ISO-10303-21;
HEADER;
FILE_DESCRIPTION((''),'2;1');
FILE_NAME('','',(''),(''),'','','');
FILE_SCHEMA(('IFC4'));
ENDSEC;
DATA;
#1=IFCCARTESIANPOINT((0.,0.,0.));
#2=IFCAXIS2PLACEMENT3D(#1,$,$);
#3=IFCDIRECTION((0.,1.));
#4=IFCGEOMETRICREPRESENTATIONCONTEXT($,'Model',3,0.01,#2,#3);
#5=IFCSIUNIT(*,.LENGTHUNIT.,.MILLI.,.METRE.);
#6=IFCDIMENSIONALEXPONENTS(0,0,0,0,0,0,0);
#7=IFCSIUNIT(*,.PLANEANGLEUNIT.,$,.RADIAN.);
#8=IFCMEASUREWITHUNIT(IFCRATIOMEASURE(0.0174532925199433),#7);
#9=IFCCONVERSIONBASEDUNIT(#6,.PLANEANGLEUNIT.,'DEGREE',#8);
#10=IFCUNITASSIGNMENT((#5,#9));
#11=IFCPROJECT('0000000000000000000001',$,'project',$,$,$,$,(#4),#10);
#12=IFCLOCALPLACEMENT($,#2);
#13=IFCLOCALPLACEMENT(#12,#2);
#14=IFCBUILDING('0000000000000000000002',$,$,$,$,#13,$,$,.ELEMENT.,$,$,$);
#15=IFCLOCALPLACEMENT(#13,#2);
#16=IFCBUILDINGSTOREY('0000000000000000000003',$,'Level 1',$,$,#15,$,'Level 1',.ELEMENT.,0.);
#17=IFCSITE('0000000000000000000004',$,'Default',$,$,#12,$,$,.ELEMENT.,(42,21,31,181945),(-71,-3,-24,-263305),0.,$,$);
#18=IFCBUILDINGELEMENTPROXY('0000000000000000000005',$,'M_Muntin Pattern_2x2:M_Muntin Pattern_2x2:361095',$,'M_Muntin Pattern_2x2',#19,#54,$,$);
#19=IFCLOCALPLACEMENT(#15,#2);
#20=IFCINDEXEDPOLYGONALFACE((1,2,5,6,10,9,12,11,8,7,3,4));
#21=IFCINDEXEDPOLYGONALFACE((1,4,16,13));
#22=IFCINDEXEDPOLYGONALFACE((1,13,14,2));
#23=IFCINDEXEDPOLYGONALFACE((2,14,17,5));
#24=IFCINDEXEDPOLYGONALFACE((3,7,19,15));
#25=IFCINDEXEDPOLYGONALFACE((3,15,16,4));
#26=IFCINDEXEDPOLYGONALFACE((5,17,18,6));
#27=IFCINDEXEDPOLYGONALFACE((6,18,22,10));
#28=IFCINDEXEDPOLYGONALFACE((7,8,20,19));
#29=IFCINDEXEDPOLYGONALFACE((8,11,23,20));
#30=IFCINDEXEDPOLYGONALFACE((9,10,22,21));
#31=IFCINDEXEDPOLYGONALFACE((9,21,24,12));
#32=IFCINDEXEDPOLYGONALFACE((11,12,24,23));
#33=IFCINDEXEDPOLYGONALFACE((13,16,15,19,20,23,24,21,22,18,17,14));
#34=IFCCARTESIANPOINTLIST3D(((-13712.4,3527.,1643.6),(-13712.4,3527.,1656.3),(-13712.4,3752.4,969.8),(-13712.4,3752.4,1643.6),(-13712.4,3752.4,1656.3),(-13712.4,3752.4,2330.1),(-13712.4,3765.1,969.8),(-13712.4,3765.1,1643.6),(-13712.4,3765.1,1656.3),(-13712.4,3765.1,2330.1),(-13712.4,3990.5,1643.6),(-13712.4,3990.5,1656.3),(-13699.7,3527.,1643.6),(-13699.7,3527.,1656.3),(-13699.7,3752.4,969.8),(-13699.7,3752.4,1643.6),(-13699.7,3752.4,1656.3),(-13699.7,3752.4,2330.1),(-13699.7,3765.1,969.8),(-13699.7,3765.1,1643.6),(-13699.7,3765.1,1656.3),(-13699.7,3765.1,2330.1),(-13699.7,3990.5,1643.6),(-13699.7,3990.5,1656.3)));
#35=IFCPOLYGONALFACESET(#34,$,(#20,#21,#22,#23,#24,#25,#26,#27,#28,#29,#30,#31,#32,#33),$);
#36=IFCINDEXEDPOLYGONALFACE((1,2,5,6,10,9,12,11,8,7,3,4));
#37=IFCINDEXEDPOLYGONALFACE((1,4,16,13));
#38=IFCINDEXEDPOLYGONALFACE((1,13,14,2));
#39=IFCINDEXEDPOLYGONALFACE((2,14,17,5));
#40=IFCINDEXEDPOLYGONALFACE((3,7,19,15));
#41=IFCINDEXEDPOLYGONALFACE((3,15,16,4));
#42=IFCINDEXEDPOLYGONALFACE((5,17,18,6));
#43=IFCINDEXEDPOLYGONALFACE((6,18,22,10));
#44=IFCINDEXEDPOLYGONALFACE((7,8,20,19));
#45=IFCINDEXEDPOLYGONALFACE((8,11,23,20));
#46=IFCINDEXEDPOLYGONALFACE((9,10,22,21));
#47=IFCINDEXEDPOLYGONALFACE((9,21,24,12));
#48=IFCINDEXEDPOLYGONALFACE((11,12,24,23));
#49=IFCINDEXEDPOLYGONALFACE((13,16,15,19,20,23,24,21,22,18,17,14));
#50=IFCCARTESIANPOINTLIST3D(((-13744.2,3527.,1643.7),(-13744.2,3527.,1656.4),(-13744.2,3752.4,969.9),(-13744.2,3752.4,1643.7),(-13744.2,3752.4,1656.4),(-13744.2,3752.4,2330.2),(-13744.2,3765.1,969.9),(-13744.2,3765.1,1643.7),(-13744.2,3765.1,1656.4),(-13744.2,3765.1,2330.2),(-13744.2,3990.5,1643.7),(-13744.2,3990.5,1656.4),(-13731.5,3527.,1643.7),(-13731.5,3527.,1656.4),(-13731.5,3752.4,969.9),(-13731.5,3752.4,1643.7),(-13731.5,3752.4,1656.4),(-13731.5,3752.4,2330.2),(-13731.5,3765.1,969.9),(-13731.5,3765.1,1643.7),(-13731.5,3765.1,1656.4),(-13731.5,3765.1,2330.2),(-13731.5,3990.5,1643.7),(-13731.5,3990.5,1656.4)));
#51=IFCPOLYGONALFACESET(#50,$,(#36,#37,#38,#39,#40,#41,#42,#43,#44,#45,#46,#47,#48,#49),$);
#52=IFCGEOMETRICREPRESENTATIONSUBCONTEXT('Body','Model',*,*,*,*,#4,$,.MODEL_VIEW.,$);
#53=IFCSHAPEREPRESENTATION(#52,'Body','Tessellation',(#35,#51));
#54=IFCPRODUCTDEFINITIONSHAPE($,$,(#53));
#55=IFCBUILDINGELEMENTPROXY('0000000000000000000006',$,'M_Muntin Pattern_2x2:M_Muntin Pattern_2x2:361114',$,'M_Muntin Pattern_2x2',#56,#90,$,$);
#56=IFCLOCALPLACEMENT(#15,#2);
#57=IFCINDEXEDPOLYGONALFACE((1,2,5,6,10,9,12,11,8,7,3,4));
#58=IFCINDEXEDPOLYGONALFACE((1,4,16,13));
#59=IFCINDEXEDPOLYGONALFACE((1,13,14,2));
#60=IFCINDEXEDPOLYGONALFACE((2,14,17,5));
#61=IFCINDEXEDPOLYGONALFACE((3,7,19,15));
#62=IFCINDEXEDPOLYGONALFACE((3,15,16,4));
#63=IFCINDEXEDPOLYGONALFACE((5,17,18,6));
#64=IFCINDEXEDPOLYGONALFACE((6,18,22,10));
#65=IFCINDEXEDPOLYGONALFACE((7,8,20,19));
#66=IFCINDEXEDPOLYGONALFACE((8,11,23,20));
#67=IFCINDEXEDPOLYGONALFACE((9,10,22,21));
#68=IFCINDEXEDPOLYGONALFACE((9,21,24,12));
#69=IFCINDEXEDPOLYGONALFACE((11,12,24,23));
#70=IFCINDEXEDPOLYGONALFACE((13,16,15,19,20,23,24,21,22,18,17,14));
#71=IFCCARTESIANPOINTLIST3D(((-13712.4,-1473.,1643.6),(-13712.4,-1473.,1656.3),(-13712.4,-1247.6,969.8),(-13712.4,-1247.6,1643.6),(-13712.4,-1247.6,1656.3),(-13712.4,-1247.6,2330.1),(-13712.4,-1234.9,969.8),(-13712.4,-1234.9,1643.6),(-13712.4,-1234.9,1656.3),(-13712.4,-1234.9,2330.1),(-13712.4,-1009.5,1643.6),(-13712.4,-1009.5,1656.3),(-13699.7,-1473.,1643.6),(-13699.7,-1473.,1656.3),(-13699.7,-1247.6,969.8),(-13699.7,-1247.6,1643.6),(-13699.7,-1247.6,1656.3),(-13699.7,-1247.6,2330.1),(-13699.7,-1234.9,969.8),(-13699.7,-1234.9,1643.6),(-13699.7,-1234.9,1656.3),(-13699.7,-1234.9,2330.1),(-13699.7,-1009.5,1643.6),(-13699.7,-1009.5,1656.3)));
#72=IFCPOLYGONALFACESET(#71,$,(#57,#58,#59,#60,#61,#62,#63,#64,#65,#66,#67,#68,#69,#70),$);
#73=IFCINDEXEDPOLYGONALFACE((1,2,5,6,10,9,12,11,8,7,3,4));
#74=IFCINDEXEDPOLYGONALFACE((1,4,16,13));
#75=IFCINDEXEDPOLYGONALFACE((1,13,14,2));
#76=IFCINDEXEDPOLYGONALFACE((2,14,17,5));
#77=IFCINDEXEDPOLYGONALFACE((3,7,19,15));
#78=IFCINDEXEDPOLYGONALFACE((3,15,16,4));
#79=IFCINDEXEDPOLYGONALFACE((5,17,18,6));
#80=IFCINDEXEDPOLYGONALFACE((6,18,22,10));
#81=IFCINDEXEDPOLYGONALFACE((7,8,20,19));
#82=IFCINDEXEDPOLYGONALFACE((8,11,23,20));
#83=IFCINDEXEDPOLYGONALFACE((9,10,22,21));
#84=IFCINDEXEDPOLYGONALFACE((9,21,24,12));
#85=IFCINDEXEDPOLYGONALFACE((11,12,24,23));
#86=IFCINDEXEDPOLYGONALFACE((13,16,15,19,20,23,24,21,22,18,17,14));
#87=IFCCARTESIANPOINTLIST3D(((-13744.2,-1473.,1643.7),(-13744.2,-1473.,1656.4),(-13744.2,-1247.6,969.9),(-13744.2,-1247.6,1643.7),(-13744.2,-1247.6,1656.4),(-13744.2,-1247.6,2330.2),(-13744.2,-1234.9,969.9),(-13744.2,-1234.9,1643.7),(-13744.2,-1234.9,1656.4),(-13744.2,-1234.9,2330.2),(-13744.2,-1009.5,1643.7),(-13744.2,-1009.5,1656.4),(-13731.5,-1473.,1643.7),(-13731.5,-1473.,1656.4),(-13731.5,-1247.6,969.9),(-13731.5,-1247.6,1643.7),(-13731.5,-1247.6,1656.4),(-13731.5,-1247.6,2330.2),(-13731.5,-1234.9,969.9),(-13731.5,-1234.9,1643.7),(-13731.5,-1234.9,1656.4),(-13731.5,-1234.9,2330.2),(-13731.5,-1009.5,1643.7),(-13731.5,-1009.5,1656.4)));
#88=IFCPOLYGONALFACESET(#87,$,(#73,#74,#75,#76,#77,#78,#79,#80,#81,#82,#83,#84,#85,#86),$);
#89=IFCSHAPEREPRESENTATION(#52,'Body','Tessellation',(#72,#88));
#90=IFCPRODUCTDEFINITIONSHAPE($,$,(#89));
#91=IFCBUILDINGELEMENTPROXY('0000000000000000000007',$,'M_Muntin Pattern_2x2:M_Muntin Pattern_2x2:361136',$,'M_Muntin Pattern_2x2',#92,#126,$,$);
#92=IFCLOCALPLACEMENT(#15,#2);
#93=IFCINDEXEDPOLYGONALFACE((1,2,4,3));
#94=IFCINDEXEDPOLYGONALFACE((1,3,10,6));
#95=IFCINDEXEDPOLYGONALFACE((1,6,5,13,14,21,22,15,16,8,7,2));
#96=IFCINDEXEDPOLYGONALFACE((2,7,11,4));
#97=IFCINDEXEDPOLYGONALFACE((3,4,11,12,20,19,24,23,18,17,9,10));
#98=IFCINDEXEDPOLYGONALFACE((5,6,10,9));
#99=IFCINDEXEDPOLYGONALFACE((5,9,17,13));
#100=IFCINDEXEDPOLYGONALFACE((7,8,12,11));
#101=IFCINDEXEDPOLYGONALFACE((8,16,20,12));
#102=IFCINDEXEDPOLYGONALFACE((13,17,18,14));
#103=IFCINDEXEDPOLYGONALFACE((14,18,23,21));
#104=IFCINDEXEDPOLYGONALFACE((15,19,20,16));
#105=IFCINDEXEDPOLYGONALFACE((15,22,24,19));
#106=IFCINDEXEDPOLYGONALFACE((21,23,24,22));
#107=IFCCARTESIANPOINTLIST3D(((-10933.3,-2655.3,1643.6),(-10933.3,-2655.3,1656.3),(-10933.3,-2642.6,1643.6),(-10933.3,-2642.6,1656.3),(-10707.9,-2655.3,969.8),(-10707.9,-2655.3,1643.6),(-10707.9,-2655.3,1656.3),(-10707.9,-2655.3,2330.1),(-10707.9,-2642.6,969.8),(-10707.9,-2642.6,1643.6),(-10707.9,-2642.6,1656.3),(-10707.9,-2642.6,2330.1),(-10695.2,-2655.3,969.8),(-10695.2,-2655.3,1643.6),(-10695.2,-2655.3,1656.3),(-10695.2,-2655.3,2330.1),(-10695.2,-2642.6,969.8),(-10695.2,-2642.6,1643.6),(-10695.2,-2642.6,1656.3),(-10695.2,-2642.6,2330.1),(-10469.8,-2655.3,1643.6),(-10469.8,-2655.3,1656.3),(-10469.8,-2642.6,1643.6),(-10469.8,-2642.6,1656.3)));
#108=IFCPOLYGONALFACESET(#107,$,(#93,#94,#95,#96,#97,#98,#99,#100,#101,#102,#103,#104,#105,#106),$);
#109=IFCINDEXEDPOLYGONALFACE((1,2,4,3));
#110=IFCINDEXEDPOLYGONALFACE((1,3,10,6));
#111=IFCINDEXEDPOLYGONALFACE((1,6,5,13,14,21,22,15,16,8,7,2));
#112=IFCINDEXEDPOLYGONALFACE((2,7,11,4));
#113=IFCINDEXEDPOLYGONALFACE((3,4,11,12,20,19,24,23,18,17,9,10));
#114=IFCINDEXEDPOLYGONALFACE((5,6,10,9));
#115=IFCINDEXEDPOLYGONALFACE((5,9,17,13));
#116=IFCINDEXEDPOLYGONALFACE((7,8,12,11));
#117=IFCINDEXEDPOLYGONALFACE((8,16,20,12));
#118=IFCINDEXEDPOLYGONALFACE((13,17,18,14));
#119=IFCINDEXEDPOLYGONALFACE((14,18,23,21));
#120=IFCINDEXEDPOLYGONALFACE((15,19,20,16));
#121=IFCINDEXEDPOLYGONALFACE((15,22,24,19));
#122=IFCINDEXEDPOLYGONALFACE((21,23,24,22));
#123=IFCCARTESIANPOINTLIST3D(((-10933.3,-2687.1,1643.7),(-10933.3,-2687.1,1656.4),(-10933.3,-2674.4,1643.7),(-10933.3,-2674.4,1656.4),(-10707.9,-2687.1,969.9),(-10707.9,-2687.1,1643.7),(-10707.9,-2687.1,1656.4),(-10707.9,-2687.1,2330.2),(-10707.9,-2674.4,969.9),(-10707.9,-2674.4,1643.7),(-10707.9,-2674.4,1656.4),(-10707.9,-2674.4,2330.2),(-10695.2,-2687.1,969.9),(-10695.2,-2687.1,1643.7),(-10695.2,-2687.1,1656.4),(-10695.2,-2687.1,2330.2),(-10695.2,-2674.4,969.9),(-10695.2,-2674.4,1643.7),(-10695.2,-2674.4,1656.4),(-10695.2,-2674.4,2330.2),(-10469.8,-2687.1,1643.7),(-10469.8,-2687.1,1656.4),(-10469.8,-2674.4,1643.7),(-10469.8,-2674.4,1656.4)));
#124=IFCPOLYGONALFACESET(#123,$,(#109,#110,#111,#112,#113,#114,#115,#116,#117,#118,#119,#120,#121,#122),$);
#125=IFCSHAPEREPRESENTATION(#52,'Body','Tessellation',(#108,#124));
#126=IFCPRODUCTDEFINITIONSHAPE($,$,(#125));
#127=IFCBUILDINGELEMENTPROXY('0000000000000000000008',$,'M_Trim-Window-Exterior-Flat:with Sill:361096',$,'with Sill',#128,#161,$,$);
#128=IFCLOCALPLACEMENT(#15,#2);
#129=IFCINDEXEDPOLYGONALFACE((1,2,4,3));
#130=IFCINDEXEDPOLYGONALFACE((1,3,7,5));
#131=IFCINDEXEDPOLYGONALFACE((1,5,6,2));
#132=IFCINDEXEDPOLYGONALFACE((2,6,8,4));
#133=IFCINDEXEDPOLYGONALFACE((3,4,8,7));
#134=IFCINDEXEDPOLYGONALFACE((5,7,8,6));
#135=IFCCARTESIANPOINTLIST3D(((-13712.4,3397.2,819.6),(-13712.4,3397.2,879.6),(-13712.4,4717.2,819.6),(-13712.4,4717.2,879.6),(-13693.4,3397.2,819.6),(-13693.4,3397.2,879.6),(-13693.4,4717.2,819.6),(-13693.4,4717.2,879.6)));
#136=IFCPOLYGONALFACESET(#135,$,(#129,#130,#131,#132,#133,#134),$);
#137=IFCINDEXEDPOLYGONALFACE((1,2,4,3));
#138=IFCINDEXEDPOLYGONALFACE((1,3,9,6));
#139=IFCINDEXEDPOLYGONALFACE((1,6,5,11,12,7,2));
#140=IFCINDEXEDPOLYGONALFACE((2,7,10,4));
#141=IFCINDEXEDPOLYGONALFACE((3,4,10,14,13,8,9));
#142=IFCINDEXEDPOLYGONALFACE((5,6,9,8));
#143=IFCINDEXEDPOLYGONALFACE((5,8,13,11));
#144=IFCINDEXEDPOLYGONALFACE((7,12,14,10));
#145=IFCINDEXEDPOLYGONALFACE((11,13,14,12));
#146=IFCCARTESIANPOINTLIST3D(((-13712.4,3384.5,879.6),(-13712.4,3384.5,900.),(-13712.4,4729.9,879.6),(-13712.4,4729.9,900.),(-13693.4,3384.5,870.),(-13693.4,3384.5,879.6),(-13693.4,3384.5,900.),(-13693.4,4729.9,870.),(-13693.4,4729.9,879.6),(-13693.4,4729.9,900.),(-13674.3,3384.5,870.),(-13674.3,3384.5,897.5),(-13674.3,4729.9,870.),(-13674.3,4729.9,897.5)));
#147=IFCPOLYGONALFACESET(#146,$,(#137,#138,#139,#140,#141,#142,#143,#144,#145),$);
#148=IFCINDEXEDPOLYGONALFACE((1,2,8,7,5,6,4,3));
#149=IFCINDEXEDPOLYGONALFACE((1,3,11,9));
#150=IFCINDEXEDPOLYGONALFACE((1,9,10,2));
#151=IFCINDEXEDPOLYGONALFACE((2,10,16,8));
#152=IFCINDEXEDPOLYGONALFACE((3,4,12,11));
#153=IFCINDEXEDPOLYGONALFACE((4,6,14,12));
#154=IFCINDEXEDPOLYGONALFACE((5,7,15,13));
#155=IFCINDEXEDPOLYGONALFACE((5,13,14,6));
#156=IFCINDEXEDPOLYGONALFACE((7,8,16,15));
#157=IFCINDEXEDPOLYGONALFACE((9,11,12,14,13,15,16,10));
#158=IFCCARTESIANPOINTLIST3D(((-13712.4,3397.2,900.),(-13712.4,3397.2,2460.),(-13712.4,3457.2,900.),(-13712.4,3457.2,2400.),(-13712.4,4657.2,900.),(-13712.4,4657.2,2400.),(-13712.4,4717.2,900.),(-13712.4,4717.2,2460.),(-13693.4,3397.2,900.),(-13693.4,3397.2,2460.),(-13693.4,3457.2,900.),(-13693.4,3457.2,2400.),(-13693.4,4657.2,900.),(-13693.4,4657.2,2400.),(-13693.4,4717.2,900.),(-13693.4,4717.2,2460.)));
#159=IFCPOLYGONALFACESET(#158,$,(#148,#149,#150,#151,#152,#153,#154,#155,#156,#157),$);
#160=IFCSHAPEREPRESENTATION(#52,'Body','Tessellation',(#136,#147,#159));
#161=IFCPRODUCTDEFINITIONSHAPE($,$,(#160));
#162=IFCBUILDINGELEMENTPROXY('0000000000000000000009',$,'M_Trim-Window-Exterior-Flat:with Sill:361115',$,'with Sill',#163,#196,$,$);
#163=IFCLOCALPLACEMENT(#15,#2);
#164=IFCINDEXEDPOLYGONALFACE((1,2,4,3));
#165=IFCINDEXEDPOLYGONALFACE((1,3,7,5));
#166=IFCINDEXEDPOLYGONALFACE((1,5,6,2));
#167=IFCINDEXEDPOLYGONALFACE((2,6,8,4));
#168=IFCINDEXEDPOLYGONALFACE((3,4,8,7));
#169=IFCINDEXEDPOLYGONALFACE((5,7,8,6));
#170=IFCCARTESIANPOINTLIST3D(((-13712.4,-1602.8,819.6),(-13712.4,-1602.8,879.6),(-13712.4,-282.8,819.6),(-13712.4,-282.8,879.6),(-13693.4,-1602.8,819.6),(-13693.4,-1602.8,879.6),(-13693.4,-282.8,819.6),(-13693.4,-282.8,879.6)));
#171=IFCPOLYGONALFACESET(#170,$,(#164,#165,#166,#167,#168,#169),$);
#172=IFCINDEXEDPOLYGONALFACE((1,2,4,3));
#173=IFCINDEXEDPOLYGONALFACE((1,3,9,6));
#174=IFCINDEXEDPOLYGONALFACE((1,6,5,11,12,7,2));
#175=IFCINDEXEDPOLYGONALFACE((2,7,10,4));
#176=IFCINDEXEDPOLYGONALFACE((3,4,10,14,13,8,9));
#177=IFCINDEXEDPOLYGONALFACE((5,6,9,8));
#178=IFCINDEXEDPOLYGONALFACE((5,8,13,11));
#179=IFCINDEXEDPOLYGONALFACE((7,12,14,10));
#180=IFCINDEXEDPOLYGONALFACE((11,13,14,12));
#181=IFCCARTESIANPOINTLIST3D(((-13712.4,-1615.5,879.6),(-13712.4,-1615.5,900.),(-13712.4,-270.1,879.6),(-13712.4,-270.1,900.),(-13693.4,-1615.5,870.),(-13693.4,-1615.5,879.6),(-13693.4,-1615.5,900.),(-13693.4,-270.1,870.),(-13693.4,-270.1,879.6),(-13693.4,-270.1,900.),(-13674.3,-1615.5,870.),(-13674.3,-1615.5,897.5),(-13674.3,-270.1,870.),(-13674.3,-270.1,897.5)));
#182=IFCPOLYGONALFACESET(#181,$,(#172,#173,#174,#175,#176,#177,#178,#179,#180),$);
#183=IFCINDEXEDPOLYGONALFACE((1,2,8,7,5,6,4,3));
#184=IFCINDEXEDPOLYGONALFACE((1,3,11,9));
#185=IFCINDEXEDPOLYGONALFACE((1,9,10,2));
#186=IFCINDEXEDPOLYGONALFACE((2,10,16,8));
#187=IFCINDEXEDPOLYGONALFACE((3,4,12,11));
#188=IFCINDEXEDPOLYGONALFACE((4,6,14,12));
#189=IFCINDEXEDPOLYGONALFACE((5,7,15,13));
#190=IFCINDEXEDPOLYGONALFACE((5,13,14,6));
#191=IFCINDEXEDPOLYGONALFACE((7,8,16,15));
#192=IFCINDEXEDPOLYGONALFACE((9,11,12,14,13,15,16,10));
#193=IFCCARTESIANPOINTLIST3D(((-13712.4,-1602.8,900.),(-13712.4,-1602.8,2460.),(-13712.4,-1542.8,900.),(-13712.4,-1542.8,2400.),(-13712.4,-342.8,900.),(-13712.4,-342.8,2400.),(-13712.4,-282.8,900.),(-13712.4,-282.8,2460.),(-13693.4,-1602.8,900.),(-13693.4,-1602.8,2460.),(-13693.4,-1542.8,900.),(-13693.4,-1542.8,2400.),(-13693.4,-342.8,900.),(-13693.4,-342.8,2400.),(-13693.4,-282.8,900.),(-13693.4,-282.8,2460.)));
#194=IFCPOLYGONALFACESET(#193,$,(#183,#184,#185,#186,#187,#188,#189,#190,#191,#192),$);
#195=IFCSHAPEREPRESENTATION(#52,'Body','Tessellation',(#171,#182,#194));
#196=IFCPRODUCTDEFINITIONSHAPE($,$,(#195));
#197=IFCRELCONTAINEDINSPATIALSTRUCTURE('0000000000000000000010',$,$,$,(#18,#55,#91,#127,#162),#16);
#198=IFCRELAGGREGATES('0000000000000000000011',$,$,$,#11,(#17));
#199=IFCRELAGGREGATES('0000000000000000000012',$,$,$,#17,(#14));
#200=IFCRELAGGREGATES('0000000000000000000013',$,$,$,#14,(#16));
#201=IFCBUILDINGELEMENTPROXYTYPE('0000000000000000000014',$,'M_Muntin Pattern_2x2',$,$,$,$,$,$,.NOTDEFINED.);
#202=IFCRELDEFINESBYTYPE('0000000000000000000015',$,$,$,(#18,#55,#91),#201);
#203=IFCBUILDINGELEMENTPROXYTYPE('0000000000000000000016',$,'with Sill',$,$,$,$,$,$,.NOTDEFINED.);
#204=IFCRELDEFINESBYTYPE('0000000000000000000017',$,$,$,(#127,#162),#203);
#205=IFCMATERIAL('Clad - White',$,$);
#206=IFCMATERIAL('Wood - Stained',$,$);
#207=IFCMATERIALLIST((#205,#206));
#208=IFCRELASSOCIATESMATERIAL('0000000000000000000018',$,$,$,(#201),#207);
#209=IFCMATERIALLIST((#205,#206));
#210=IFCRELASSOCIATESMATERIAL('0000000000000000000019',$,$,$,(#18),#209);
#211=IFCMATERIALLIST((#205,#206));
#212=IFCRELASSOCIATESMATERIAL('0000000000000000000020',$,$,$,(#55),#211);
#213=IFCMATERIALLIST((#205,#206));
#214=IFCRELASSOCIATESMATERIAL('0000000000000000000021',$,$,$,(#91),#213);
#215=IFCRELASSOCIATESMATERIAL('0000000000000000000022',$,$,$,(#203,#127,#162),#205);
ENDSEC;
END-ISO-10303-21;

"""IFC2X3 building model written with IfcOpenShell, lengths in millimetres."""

from ifc_helpers import new_model, entity, si_unit, converted_unit, direction, frame, frame_2d, origin, place, context, subcontext, project, spatial, polyline, rectangle, outline, extrude, source, transform, mapped, material, material_list, type_object, type_shapes, element, save


model = new_model("IFC2X3")

# Units and contexts
model_context = context("Model", 3, precision=0.01, world=origin(), true_north=direction((0.0, 1.0)))
body_context = subcontext(model_context, "Body", "Model", "MODEL_VIEW")
ifc_project = project(units=[si_unit("LENGTHUNIT", "METRE", prefix="MILLI"), converted_unit("PLANEANGLEUNIT", "DEGREE", entity("IfcRatioMeasure", 0.0174532925199433), si_unit("PLANEANGLEUNIT", "RADIAN"), dimensions=[0, 0, 0, 0, 0, 0, 0])], contexts=[model_context])

# Site, building, storey
site_placement = place(None, origin())
site = spatial("IfcSite", under=ifc_project, at=site_placement, Name="Default", CompositionType="ELEMENT", RefLatitude=(42, 21, 31, 181945), RefLongitude=(-71, -3, -24, -263305), RefElevation=0.0)
building_placement = place(site_placement, origin())
building = spatial("IfcBuilding", under=site, at=building_placement, CompositionType="ELEMENT")
storey_placement = place(building_placement, origin())
storey = spatial("IfcBuildingStorey", under=building, at=storey_placement, Name="Level 1", LongName="Level 1", CompositionType="ELEMENT", Elevation=0.0)

# Building element proxies
ifc_material_1 = material(Name="Clad - White")
ifc_material_2 = material(Name="Wood - Stained")
ifc_material_list_1 = material_list([ifc_material_1, ifc_material_2])
ifc_material_list_2 = material_list([ifc_material_1, ifc_material_2])
building_element_proxy_type_1 = type_object("IfcBuildingElementProxyType", Name="M_Muntin Pattern_2x2", PredefinedType="NOTDEFINED", material=ifc_material_list_2)
shared_shape_1 = source(origin(), body_context, "Body", "SweptSolid", [
    extrude(outline(polyline([(6.4, -6.4), (680.1, -6.4), (680.1, 6.3), (6.4, 6.3), (6.4, 231.7), (-6.3, 231.7), (-6.3, 6.3), (-680.2, 6.3), (-680.2, -6.4), (-6.3, -6.4), (-6.3, -231.7), (6.4, -231.7), (6.4, -6.4)])), frame((0.0, -22.2, 680.1), z_axis=(0.0, 1.0, 0.0), x_axis=(0.0, 0.0, 1.0)), (0.0, 0.0, 1.0), 12.7),
    extrude(outline(polyline([(6.4, -6.4), (680.1, -6.4), (680.1, 6.3), (6.4, 6.3), (6.4, 231.7), (-6.3, 231.7), (-6.3, 6.3), (-680.2, 6.3), (-680.2, -6.4), (-6.3, -6.4), (-6.3, -231.7), (6.4, -231.7), (6.4, -6.4)])), frame((0.0, 9.5, 680.2), z_axis=(0.0, 1.0, 0.0), x_axis=(0.0, 0.0, 1.0)), (0.0, 0.0, 1.0), 12.7),
])
type_shapes(building_element_proxy_type_1, [shared_shape_1])
proxy_1_placement = place(storey_placement, frame((-13722.0, 3758.7, 969.9), z_axis=(0.0, 0.0, 1.0), x_axis=(0.0, 1.0, 0.0)))
element("IfcBuildingElementProxy", 1, at=proxy_1_placement, inside=storey, type_object=building_element_proxy_type_1, material=ifc_material_list_1, Name="M_Muntin Pattern_2x2:M_Muntin Pattern_2x2:361095", ObjectType="M_Muntin Pattern_2x2", context=body_context, shape_type="MappedRepresentation", body=[
    mapped(shared_shape_1, transform((0.0, 0.0, 0.0), scale=1.0)),
])
ifc_material_list_3 = material_list([ifc_material_1, ifc_material_2])
proxy_2_placement = place(storey_placement, frame((-13722.0, -1241.3, 969.9), z_axis=(0.0, 0.0, 1.0), x_axis=(0.0, 1.0, 0.0)))
element("IfcBuildingElementProxy", 2, at=proxy_2_placement, inside=storey, type_object=building_element_proxy_type_1, material=ifc_material_list_3, Name="M_Muntin Pattern_2x2:M_Muntin Pattern_2x2:361114", ObjectType="M_Muntin Pattern_2x2", context=body_context, shape_type="MappedRepresentation", body=[
    mapped(shared_shape_1, transform((0.0, 0.0, 0.0), scale=1.0)),
])
ifc_material_list_4 = material_list([ifc_material_1, ifc_material_2])
proxy_3_placement = place(storey_placement, frame((-10701.5, -2664.9, 969.9), z_axis=(0.0, 0.0, 1.0), x_axis=(-1.0, 0.0, 0.0)))
element("IfcBuildingElementProxy", 3, at=proxy_3_placement, inside=storey, type_object=building_element_proxy_type_1, material=ifc_material_list_4, Name="M_Muntin Pattern_2x2:M_Muntin Pattern_2x2:361136", ObjectType="M_Muntin Pattern_2x2", context=body_context, shape_type="MappedRepresentation", body=[
    mapped(shared_shape_1, transform((0.0, 0.0, 0.0), scale=1.0)),
])
building_element_proxy_type_2 = type_object("IfcBuildingElementProxyType", Name="with Sill", PredefinedType="NOTDEFINED", material=ifc_material_1)
shared_shape_2 = source(origin(), body_context, "Body", "SweptSolid", [
    extrude(rectangle(XDim=1320.0, YDim=60.0, at=frame_2d((0.0, 0.0), x_axis=(1.0, 0.0))), frame((0.0, -1550.4, 0.0), z_axis=(0.0, 0.0, 1.0), x_axis=(-1.0, 0.0, 0.0)), (0.0, 0.0, 1.0), 19.1),
    extrude(outline(polyline([(-19.0, -15.2), (0.0, -15.2), (0.0, -5.7), (19.0, -5.7), (19.0, 14.8), (0.0, 14.8), (-19.0, 12.3), (-19.0, -15.2)])), frame((-672.7, -1514.8, 19.0), z_axis=(1.0, 0.0, 0.0), x_axis=(0.0, 0.0, -1.0)), (0.0, 0.0, 1.0), 1345.4),
    extrude(outline(polyline([(-795.0, -660.0), (765.0, -660.0), (765.0, -600.0), (-735.0, -600.0), (-735.0, 600.0), (765.0, 600.0), (765.0, 660.0), (-795.0, 660.0), (-795.0, -660.0)])), frame((0.0, -735.0, 0.0), z_axis=(0.0, 0.0, 1.0), x_axis=(0.0, -1.0, 0.0)), (0.0, 0.0, 1.0), 19.1),
])
type_shapes(building_element_proxy_type_2, [shared_shape_2])
for number, where, z_axis, x_axis, name in (
    (4, (-13712.4, 4057.2, 2400.0), (1.0, 0.0, 0.0), (0.0, 1.0, 0.0), "M_Trim-Window-Exterior-Flat:with Sill:361096"),
    (5, (-13712.4, -942.8, 2400.0), (1.0, 0.0, 0.0), (0.0, 1.0, 0.0), "M_Trim-Window-Exterior-Flat:with Sill:361115"),
):
    element("IfcBuildingElementProxy", number, at=place(storey_placement, frame(where, z_axis=z_axis, x_axis=x_axis)), inside=storey, type_object=building_element_proxy_type_2, material=ifc_material_1, Name=name, ObjectType="with Sill", context=body_context, shape_type="MappedRepresentation", body=[
        mapped(shared_shape_2, transform((0.0, 0.0, 0.0), scale=1.0)),
    ])

save(model, "model.ifc")
